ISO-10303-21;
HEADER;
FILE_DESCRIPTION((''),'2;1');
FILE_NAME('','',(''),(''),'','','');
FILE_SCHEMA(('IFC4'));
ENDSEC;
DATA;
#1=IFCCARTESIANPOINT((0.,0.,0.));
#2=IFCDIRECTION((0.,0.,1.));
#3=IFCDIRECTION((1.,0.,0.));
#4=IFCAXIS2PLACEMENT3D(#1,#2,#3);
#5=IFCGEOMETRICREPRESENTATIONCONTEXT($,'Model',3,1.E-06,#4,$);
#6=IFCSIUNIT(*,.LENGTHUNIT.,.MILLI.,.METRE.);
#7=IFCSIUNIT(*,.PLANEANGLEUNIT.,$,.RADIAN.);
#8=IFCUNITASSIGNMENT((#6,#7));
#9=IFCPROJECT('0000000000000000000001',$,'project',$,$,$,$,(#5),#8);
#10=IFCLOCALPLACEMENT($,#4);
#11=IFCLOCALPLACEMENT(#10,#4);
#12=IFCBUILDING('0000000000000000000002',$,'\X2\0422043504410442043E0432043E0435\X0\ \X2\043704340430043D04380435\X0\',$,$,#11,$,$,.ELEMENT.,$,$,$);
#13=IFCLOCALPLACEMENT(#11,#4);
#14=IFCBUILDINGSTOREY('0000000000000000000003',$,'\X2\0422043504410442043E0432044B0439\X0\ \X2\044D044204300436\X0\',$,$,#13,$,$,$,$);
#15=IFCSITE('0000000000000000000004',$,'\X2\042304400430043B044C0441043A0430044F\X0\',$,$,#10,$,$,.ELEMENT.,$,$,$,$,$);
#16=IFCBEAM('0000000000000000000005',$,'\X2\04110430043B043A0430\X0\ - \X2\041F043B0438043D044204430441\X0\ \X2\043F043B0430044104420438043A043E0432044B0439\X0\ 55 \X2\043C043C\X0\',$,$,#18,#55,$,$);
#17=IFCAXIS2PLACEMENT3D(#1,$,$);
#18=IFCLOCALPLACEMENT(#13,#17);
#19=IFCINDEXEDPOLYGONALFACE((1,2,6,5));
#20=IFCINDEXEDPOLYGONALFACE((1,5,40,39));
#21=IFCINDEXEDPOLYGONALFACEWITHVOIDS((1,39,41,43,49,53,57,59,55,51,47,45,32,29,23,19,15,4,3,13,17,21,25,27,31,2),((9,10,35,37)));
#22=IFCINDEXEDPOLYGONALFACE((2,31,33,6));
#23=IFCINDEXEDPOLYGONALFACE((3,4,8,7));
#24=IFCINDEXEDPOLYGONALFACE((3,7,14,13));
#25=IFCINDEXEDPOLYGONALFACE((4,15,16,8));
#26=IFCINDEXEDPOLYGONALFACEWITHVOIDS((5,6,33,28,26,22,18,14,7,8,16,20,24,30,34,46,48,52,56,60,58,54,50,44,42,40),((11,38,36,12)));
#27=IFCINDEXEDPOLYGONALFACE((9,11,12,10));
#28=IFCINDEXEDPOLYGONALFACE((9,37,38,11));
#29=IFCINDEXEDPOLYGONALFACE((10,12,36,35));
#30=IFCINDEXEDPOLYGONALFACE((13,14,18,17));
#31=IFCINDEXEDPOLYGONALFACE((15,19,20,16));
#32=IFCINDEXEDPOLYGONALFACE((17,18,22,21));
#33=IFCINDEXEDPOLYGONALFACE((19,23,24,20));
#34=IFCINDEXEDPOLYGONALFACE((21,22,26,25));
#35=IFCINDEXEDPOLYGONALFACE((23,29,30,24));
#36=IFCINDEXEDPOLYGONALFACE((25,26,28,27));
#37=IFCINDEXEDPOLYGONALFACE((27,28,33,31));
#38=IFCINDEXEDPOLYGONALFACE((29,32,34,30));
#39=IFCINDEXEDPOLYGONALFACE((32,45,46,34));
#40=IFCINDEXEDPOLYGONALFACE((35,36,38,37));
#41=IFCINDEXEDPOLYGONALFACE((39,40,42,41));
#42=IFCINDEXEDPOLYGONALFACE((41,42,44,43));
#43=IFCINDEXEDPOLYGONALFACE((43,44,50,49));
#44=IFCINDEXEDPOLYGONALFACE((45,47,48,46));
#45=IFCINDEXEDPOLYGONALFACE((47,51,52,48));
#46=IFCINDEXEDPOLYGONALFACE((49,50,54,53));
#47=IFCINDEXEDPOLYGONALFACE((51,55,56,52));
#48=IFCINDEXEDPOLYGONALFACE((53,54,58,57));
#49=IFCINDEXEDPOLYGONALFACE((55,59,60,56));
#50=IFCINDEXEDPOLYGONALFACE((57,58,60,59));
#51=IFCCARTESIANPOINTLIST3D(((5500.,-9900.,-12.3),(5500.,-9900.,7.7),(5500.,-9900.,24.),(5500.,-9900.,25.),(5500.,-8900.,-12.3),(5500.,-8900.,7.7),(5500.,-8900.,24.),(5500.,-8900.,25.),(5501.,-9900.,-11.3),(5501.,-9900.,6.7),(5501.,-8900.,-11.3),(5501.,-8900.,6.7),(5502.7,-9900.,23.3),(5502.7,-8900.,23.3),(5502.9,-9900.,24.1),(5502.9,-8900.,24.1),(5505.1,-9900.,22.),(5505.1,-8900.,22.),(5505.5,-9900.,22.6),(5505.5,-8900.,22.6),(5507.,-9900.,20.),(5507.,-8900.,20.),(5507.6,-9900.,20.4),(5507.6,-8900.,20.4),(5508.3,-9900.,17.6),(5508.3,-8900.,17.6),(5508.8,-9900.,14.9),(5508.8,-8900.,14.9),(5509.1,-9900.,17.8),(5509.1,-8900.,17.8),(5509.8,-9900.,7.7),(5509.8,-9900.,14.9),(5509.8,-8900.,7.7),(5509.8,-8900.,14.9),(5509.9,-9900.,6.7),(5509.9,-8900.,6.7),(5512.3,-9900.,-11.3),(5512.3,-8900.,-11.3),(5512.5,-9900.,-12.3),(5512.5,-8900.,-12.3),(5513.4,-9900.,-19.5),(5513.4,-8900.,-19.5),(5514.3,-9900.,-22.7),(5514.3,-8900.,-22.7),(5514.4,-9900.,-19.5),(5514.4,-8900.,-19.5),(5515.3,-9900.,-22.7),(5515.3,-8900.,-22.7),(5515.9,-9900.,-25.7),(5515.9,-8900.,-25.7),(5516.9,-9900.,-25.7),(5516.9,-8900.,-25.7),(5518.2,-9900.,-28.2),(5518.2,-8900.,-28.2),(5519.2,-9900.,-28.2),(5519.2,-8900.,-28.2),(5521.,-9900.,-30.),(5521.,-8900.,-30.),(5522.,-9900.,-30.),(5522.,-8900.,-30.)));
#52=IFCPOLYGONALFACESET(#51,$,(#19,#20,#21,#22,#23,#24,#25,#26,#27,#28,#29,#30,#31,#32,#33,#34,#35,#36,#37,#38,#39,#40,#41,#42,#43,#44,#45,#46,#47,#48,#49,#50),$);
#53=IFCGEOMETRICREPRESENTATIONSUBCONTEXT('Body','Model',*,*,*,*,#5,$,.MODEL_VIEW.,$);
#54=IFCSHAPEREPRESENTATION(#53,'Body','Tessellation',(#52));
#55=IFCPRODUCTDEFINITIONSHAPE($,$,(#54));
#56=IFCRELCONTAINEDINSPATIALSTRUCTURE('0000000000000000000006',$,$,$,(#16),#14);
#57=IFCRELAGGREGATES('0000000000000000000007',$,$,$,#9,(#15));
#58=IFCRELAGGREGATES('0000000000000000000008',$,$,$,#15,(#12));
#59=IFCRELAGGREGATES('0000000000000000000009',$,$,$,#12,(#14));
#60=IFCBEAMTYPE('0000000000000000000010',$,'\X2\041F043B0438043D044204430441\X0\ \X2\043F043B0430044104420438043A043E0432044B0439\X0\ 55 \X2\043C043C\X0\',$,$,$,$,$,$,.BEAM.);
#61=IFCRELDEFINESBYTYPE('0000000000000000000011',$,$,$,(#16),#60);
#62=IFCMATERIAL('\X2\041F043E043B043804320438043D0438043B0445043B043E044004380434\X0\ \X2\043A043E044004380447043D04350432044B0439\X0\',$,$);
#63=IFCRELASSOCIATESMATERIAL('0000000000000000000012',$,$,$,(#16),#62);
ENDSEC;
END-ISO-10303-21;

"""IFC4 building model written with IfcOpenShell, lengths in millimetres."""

from ifc_helpers import new_model, si_unit, frame, origin_with_axes, place, context, subcontext, project, spatial, line, arc, indexed_curve, outline, extrude, source, transform, mapped, material, type_object, element, save


model = new_model("IFC4")

# Units and contexts
model_context = context("Model", 3, precision=1e-06, world=origin_with_axes())
body_context = subcontext(model_context, "Body", "Model", "MODEL_VIEW")
ifc_project = project(units=[si_unit("LENGTHUNIT", "METRE", prefix="MILLI"), si_unit("PLANEANGLEUNIT", "RADIAN")], contexts=[model_context])

# Site, building, storey
site_placement = place(None, origin_with_axes())
site = spatial("IfcSite", under=ifc_project, at=site_placement, Name="Уральская", CompositionType="ELEMENT")
building_placement = place(site_placement, origin_with_axes())
building = spatial("IfcBuilding", under=site, at=building_placement, Name="Тестовое здание", CompositionType="ELEMENT")
storey_placement = place(building_placement, origin_with_axes())
storey = spatial("IfcBuildingStorey", under=building, at=storey_placement, Name="Тестовый этаж")

# Beam
ifc_material_1 = material(Name="Поливинилхлорид коричневый")
beam_type_1 = type_object("IfcBeamType", Name="Плинтус пластиковый 55 мм", PredefinedType="BEAM")
shared_shape_1 = source(origin_with_axes(), body_context, "Body", "SweptSolid", [
    extrude(outline(indexed_curve([(0.0, 55.0), (-6.6, 51.5), (-9.8, 44.9), (-14.4, 10.5), (-16.9, 4.3), (-22.0, 0.0), (-21.0, 0.0), (-15.9, 4.3), (-13.4, 10.5), (-12.5, 17.7), (0.0, 17.7), (0.0, 37.7), (-9.8, 37.7), (-8.8, 44.9), (-6.1, 51.0), (0.0, 54.0), (-1.0, 18.7), (-12.3, 18.7), (-9.9, 36.7), (-1.0, 36.7)], segments=[arc(16, 15, 14), line(14, 13), line(13, 12), line(12, 11), line(11, 10), line(10, 9), arc(9, 8, 7), line(7, 6), arc(6, 5, 4), line(4, 3), arc(3, 2, 1), line(1, 16)], self_intersect=False), holes=[indexed_curve([(0.0, 55.0), (-6.6, 51.5), (-9.8, 44.9), (-14.4, 10.5), (-16.9, 4.3), (-22.0, 0.0), (-21.0, 0.0), (-15.9, 4.3), (-13.4, 10.5), (-12.5, 17.7), (0.0, 17.7), (0.0, 37.7), (-9.8, 37.7), (-8.8, 44.9), (-6.1, 51.0), (0.0, 54.0), (-1.0, 18.7), (-12.3, 18.7), (-9.9, 36.7), (-1.0, 36.7)], segments=[line(18, 19), line(19, 20), line(20, 17), line(17, 18)], self_intersect=False)]), origin_with_axes(), (0.0, 0.0, -1.0), 1000.0),
])
beam_1_placement = place(storey_placement, frame((5500.0, -8900.0, -30.0), z_axis=(0.0, 1.0, 0.0), x_axis=(-1.0, 0.0, 0.0)))
element("IfcBeam", 1, at=beam_1_placement, inside=storey, type_object=beam_type_1, material=ifc_material_1, Name="Балка - Плинтус пластиковый 55 мм", context=body_context, shape_type="MappedRepresentation", body=[
    mapped(shared_shape_1, transform((0.0, 0.0, 0.0), x_axis=(1.0, 0.0, 0.0), y_axis=(0.0, 1.0, 0.0), z_axis=(0.0, 0.0, 1.0), scale=1.0)),
])

save(model, "model.ifc")
